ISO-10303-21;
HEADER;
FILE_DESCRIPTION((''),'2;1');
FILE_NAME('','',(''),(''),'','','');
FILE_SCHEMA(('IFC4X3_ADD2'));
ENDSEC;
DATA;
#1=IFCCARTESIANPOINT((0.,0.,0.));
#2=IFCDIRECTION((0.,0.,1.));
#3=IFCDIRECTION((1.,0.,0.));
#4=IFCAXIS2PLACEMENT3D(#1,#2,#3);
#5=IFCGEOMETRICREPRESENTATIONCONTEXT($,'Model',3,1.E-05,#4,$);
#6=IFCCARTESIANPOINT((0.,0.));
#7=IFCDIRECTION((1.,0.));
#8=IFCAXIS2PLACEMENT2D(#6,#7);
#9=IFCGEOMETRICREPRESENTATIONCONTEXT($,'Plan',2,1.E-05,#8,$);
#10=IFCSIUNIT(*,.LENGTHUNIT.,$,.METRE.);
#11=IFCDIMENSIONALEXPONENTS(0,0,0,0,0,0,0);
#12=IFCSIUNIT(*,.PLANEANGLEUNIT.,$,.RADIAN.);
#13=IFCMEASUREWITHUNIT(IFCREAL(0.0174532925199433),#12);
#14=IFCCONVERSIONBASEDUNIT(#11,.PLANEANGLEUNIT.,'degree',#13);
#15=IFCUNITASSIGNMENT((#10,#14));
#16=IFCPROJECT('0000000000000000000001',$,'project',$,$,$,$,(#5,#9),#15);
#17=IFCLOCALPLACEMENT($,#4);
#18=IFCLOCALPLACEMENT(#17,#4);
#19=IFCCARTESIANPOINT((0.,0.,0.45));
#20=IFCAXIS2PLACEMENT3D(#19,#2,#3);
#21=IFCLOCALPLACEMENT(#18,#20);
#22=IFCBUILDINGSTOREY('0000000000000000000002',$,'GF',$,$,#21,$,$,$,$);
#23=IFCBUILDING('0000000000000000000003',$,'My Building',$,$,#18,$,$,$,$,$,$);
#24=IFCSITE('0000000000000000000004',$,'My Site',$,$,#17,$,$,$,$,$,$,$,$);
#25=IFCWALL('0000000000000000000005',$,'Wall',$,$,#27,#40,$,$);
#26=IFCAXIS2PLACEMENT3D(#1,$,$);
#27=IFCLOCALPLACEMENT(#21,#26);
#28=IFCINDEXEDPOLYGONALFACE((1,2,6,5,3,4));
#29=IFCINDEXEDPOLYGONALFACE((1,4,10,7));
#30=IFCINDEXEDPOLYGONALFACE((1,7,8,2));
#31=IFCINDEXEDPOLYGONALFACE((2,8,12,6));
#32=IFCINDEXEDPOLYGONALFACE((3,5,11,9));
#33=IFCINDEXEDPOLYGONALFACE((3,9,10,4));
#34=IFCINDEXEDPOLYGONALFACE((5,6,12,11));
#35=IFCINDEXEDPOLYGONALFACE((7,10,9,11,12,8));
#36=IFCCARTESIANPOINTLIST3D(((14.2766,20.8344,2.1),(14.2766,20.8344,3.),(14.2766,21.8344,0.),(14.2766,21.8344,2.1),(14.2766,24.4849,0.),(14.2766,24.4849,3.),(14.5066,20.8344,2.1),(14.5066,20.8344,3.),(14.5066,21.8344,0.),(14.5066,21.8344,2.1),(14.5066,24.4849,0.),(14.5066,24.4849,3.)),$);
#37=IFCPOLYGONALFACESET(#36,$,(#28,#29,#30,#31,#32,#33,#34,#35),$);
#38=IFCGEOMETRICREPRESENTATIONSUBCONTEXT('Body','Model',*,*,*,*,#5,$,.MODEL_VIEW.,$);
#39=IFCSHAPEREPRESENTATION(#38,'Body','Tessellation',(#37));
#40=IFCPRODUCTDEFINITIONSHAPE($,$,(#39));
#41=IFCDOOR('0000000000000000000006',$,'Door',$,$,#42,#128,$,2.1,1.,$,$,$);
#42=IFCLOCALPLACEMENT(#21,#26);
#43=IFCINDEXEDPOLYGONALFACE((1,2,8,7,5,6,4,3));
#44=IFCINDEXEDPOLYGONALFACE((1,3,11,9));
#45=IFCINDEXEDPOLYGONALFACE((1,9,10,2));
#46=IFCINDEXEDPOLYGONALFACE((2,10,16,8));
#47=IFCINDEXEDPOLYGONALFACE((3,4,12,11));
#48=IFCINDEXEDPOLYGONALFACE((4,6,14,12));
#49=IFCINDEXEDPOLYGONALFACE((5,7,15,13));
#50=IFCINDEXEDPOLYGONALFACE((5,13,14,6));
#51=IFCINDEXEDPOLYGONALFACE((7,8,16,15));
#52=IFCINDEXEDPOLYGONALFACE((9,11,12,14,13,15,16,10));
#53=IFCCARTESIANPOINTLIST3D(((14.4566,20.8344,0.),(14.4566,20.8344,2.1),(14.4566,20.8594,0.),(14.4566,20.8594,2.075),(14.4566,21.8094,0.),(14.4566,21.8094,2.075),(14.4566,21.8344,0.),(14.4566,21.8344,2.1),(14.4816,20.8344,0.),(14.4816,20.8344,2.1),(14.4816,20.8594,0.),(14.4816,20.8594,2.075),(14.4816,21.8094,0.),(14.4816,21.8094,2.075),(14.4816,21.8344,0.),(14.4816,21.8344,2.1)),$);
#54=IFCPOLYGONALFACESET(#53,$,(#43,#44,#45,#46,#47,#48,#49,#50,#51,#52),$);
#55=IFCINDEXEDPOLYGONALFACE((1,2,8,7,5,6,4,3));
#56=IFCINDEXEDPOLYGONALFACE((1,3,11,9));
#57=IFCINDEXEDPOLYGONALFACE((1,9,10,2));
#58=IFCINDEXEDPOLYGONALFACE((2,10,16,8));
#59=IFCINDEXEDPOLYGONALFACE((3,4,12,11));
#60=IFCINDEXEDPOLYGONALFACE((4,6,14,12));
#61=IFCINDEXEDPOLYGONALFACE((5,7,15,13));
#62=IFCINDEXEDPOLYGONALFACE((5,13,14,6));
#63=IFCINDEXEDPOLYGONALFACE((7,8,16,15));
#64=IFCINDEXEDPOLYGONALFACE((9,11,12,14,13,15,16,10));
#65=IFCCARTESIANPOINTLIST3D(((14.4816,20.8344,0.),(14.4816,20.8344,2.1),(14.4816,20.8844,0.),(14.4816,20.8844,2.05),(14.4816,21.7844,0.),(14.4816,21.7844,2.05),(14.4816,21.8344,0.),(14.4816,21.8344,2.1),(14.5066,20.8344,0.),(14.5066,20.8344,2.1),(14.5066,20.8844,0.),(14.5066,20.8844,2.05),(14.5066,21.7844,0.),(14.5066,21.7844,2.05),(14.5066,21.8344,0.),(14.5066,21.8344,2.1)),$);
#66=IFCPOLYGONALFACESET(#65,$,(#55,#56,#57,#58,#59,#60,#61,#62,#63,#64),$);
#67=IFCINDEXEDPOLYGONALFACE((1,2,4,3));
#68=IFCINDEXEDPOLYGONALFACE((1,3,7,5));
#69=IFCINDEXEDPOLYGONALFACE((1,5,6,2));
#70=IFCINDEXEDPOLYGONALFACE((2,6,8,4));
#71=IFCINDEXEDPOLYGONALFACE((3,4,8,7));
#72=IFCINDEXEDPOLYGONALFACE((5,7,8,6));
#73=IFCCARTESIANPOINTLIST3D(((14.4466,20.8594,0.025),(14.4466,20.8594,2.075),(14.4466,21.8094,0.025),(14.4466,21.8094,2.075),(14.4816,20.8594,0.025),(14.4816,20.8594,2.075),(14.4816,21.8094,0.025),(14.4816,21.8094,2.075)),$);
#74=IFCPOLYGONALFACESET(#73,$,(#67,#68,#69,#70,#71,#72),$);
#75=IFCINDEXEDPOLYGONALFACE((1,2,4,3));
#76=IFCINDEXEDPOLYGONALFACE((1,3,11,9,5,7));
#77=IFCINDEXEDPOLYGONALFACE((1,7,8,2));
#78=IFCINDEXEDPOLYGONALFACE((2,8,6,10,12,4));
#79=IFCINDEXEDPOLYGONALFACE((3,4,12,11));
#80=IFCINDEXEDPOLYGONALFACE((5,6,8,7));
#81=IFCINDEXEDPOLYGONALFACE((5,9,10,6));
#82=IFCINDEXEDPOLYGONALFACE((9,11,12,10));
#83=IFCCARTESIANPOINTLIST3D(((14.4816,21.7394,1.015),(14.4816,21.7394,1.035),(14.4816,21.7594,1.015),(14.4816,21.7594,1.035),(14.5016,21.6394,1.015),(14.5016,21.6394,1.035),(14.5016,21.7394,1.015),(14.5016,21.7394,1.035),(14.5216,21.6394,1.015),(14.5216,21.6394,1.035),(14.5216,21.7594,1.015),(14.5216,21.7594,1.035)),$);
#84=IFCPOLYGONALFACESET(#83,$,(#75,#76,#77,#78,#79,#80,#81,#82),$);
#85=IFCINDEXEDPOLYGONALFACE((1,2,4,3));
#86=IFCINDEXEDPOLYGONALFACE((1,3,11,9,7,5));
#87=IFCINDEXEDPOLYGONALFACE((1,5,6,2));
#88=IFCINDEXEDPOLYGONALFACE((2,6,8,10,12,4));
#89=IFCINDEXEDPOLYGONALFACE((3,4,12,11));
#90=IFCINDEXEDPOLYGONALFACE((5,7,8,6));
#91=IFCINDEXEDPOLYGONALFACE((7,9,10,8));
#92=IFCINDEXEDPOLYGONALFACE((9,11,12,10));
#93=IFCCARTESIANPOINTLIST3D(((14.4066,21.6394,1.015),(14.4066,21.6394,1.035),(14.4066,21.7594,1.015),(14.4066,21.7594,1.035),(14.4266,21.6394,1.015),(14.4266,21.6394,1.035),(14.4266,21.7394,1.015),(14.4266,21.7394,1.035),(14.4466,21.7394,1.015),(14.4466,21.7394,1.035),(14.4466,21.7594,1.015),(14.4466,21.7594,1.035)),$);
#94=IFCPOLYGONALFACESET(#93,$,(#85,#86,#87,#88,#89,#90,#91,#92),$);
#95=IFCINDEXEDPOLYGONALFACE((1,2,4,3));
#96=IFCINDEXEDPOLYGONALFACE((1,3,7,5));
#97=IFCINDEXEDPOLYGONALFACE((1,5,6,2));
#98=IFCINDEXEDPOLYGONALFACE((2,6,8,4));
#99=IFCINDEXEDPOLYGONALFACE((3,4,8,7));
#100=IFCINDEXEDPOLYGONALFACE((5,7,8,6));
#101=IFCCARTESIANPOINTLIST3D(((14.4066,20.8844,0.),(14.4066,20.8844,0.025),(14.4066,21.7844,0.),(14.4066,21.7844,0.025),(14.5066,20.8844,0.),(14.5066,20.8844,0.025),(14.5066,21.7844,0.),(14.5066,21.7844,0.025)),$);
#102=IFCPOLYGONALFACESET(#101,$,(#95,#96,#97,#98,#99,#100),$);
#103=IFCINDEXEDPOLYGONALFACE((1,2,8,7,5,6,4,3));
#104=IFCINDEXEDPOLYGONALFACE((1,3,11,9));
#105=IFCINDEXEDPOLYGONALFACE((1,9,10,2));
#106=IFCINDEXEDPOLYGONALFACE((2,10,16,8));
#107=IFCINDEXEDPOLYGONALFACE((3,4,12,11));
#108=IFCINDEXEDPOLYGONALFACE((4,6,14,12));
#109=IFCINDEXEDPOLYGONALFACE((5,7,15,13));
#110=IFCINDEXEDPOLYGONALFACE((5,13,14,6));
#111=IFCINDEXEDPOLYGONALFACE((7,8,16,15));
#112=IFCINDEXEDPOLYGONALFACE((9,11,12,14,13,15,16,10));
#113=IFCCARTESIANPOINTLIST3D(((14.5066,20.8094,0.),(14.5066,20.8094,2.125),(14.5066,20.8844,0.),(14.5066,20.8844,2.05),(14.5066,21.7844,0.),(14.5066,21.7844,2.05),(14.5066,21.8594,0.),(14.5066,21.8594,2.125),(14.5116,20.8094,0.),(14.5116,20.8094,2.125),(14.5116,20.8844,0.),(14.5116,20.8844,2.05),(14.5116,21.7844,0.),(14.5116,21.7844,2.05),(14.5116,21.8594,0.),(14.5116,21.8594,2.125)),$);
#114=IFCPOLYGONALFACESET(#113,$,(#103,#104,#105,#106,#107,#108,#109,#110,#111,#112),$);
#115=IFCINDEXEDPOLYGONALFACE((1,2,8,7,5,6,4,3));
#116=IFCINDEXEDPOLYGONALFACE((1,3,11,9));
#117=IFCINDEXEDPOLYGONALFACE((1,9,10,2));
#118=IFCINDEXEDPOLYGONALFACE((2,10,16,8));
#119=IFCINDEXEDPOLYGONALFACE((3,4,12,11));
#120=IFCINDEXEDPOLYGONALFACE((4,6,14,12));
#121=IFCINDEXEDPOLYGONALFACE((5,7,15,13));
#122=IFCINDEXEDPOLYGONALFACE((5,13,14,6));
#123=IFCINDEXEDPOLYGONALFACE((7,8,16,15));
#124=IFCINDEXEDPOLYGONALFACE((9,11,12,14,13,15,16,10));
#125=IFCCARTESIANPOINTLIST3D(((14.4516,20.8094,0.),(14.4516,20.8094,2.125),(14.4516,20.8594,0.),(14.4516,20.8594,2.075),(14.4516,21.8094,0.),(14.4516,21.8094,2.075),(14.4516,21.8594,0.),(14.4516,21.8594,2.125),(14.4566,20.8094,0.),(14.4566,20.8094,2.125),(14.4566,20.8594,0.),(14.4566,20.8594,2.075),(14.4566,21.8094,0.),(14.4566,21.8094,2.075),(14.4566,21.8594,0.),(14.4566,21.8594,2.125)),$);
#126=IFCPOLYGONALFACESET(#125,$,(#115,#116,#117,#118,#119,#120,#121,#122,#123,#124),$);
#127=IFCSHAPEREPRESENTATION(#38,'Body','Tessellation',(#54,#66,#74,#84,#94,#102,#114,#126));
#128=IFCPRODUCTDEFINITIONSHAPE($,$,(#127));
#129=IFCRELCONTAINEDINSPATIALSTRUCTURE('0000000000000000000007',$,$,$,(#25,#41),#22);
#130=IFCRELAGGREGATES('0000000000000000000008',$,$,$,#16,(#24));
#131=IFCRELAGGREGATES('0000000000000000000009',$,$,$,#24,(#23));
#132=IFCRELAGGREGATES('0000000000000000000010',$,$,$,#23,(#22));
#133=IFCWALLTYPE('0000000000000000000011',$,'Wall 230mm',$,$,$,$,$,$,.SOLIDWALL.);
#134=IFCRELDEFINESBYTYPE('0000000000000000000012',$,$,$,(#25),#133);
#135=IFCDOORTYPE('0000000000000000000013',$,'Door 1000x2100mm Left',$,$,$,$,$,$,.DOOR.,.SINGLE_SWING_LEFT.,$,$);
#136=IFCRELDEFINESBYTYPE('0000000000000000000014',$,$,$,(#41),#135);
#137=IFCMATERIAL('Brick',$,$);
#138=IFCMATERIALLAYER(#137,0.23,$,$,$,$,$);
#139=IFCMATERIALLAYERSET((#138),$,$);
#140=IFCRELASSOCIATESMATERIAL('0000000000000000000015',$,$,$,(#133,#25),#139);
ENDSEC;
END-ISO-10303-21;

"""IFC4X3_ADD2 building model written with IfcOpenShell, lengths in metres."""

from ifc_helpers import new_model, entity, si_unit, converted_unit, frame, origin_with_axes, origin_2d_with_axis, place, context, subcontext, project, spatial, line, indexed_curve, outline, extrude, shape, source, transform, mapped, material, layer, layer_set, layer_usage, type_object, type_shapes, element, fill, save


model = new_model("IFC4X3_ADD2")

# Units and contexts
model_context = context("Model", 3, precision=1e-05, world=origin_with_axes())
plan_context = context("Plan", 2, precision=1e-05, world=origin_2d_with_axis())
body_context_1 = subcontext(model_context, "Body", "Model", "MODEL_VIEW")
body_context_2 = subcontext(plan_context, "Body", "Plan", "PLAN_VIEW")
ifc_project = project(units=[si_unit("LENGTHUNIT", "METRE"), converted_unit("PLANEANGLEUNIT", "degree", entity("IfcReal", 0.0174532925199433), si_unit("PLANEANGLEUNIT", "RADIAN"), dimensions=[0, 0, 0, 0, 0, 0, 0])], contexts=[model_context, plan_context])

# Site, building, storey
site_placement = place(None, origin_with_axes())
site = spatial("IfcSite", under=ifc_project, at=site_placement, Name="My Site")
building_placement = place(site_placement, origin_with_axes())
building = spatial("IfcBuilding", under=site, at=building_placement, Name="My Building")
storey_placement = place(building_placement, frame((0.0, 0.0, 0.45), z_axis=(0.0, 0.0, 1.0), x_axis=(1.0, 0.0, 0.0)))
storey = spatial("IfcBuildingStorey", under=building, at=storey_placement, Name="GF")

# Shared definitions
ifc_material = material(Name="Brick")
ifc_layer_1 = layer(ifc_material, 0.23)
ifc_layer_set_1 = layer_set([ifc_layer_1])
wall_type_1 = type_object("IfcWallType", Name="Wall 230mm", PredefinedType="SOLIDWALL", material=ifc_layer_set_1)

# Shared definitions
shared_shape_1 = source(origin_with_axes(), body_context_1, "Body", "SweptSolid", [
    extrude(outline(indexed_curve([(0.0, 0.0), (1.0, 0.0), (1.0, 2.1), (0.0, 2.1)], segments=[line(1, 2, 3, 4, 1)])), frame((0.0, -0.6, 0.0), z_axis=(0.0, -1.0, 0.0), x_axis=(1.0, 0.0, 0.0)), (0.0, 0.0, -1.0), 1.2),
])
door_type_1 = type_object("IfcDoorType", Name="Door 1000x2100mm Left", OperationType="SINGLE_SWING_LEFT", PredefinedType="DOOR")
shared_shape_2 = source(origin_with_axes(), body_context_1, "Body", "SweptSolid", [
    extrude(outline(indexed_curve([(0.0, 0.0), (0.0, 2.1), (1.0, 2.1), (1.0, 0.0), (0.975, 0.0), (0.975, 2.075), (0.025, 2.075), (0.025, 0.0)], segments=[line(1, 2, 3, 4, 5, 6, 7, 8, 1)])), frame((0.0, 0.025, 0.0), z_axis=(0.0, -1.0, 0.0), x_axis=(1.0, 0.0, 0.0)), (0.0, 0.0, -1.0), 0.025),
    extrude(outline(indexed_curve([(0.0, 0.0), (0.0, 2.1), (1.0, 2.1), (1.0, 0.0), (0.95, 0.0), (0.95, 2.05), (0.05, 2.05), (0.05, 0.0)], segments=[line(1, 2, 3, 4, 5, 6, 7, 8, 1)])), frame((0.0, 0.0, 0.0), z_axis=(0.0, -1.0, 0.0), x_axis=(1.0, 0.0, 0.0)), (0.0, 0.0, -1.0), 0.025),
    extrude(outline(indexed_curve([(0.0, 0.0), (0.95, 0.0), (0.95, 0.035), (0.0, 0.035)], segments=[line(1, 2, 3, 4, 1)])), frame((0.025, 0.025, 0.025), z_axis=(0.0, 0.0, 1.0), x_axis=(1.0, 0.0, 0.0)), (0.0, 0.0, 1.0), 2.05),
    extrude(outline(indexed_curve([(0.0, 0.0), (0.0, -0.04), (-0.12, -0.04), (-0.12, -0.02), (-0.02, -0.02), (-0.02, 0.0)], segments=[line(1, 2, 3, 4, 5, 6, 1)])), frame((0.925, 0.025, 1.015), z_axis=(0.0, 0.0, 1.0), x_axis=(1.0, 0.0, 0.0)), (0.0, 0.0, 1.0), 0.02),
    extrude(outline(indexed_curve([(0.0, 0.0), (0.0, 0.04), (-0.12, 0.04), (-0.12, 0.02), (-0.02, 0.02), (-0.02, 0.0)], segments=[line(1, 2, 3, 4, 5, 6, 1)])), frame((0.925, 0.06, 1.015), z_axis=(0.0, 0.0, 1.0), x_axis=(1.0, 0.0, 0.0)), (0.0, 0.0, 1.0), 0.02),
    extrude(outline(indexed_curve([(0.0, 0.0), (0.9, 0.0), (0.9, 0.1), (0.0, 0.1)], segments=[line(1, 2, 3, 4, 1)])), frame((0.05, 0.0, 0.0), z_axis=(0.0, 0.0, 1.0), x_axis=(1.0, 0.0, 0.0)), (0.0, 0.0, 1.0), 0.025),
    extrude(outline(indexed_curve([(0.0, 0.0), (0.0, 2.125), (1.05, 2.125), (1.05, 0.0), (0.975, 0.0), (0.975, 2.05), (0.075, 2.05), (0.075, 0.0)], segments=[line(1, 2, 3, 4, 5, 6, 7, 8, 1)])), frame((-0.025, -0.005, 0.0), z_axis=(0.0, -1.0, 0.0), x_axis=(1.0, 0.0, 0.0)), (0.0, 0.0, -1.0), 0.005),
    extrude(outline(indexed_curve([(0.0, 0.0), (0.0, 2.125), (1.05, 2.125), (1.05, 0.0), (1.0, 0.0), (1.0, 2.075), (0.05, 2.075), (0.05, 0.0)], segments=[line(1, 2, 3, 4, 5, 6, 7, 8, 1)])), frame((-0.025, 0.05, 0.0), z_axis=(0.0, -1.0, 0.0), x_axis=(1.0, 0.0, 0.0)), (0.0, 0.0, -1.0), 0.005),
])
shared_shape_3 = source(origin_with_axes(), body_context_2, "Body", "Curve2D", [
    entity("IfcIndexedPolyCurve", entity("IfcCartesianPointList2D", [[0.0, 0.0], [0.0, 0.05], [0.025, 0.05], [0.025, 0.025], [0.05, 0.025], [0.05, 0.0]]), [entity("IfcLineIndex", [1, 2, 3, 4, 5, 6, 1])]),
    entity("IfcIndexedPolyCurve", entity("IfcCartesianPointList2D", [[1.0, 0.0], [1.0, 0.05], [0.975, 0.05], [0.975, 0.025], [0.95, 0.025], [0.95, 0.0]]), [entity("IfcLineIndex", [1, 2, 3, 4, 5, 6, 1])]),
    entity("IfcTrimmedCurve", entity("IfcEllipse", entity("IfcAxis2Placement2D", entity("IfcCartesianPoint", [0.06, 0.05]), entity("IfcDirection", [1.0, 0.0])), 0.915, 0.95), [entity("IfcCartesianPoint", [0.975, 0.05])], [entity("IfcCartesianPoint", [0.06, 1.0])], True, "CARTESIAN"),
    entity("IfcIndexedPolyCurve", entity("IfcCartesianPointList2D", [[0.025, 0.05], [0.06, 0.05], [0.06, 1.0], [0.025, 1.0]]), [entity("IfcLineIndex", [1, 2, 3, 4, 1])]),
])
type_shapes(door_type_1, [shared_shape_2, shared_shape_3])

# Wall, opening, door
ifc_layer_usage_1 = layer_usage(ifc_layer_set_1, "AXIS2", "POSITIVE", 0.0)
wall_1_placement = place(storey_placement, frame((14.5066, 20.8344, 0.0), z_axis=(0.0, 0.0, 1.0), x_axis=(0.0, 1.0, 0.0)))
wall_1 = element("IfcWall", 1, at=wall_1_placement, inside=storey, type_object=wall_type_1, material=ifc_layer_usage_1, Name="Wall", context=body_context_1, shape_type="SweptSolid", body=[
    extrude(outline(indexed_curve([(0.0, 0.0), (0.0, 0.23), (3.6505, 0.23), (3.6505, 0.0), (0.0, 0.0)], self_intersect=False)), origin_with_axes(), (0.0, 0.0, 1.0), 3.0),
])
opening_1_placement = place(wall_1_placement, frame((0.0, 0.0, 0.0), z_axis=(0.0, 0.0, 1.0), x_axis=(1.0, 0.0, 0.0)))
opening_1 = element("IfcOpeningElement", 2, at=opening_1_placement, cuts=wall_1, PredefinedType="OPENING", context=body_context_1, shape_type="MappedRepresentation", body=[
    mapped(shared_shape_1, transform((0.0, 0.0, 0.0), x_axis=(1.0, 0.0, 0.0), y_axis=(0.0, 1.0, 0.0), z_axis=(0.0, 0.0, 1.0), scale=1.0)),
])
door_1_placement = place(opening_1_placement, origin_with_axes())
door_1 = element("IfcDoor", 3, at=door_1_placement, inside=storey, type_object=door_type_1, Name="Door", OverallHeight=2.1, OverallWidth=1.0, shapes=[
    shape(body_context_1, "Body", "MappedRepresentation", [mapped(shared_shape_2, transform((0.0, 0.0, 0.0), x_axis=(1.0, 0.0, 0.0), y_axis=(0.0, 1.0, 0.0), z_axis=(0.0, 0.0, 1.0), scale=1.0))]),
    shape(body_context_2, "Body", "MappedRepresentation", [mapped(shared_shape_3, transform((0.0, 0.0, 0.0), x_axis=(1.0, 0.0, 0.0), y_axis=(0.0, 1.0, 0.0), z_axis=(0.0, 0.0, 1.0), scale=1.0))]),
])
fill(opening_1, door_1)

save(model, "model.ifc")
